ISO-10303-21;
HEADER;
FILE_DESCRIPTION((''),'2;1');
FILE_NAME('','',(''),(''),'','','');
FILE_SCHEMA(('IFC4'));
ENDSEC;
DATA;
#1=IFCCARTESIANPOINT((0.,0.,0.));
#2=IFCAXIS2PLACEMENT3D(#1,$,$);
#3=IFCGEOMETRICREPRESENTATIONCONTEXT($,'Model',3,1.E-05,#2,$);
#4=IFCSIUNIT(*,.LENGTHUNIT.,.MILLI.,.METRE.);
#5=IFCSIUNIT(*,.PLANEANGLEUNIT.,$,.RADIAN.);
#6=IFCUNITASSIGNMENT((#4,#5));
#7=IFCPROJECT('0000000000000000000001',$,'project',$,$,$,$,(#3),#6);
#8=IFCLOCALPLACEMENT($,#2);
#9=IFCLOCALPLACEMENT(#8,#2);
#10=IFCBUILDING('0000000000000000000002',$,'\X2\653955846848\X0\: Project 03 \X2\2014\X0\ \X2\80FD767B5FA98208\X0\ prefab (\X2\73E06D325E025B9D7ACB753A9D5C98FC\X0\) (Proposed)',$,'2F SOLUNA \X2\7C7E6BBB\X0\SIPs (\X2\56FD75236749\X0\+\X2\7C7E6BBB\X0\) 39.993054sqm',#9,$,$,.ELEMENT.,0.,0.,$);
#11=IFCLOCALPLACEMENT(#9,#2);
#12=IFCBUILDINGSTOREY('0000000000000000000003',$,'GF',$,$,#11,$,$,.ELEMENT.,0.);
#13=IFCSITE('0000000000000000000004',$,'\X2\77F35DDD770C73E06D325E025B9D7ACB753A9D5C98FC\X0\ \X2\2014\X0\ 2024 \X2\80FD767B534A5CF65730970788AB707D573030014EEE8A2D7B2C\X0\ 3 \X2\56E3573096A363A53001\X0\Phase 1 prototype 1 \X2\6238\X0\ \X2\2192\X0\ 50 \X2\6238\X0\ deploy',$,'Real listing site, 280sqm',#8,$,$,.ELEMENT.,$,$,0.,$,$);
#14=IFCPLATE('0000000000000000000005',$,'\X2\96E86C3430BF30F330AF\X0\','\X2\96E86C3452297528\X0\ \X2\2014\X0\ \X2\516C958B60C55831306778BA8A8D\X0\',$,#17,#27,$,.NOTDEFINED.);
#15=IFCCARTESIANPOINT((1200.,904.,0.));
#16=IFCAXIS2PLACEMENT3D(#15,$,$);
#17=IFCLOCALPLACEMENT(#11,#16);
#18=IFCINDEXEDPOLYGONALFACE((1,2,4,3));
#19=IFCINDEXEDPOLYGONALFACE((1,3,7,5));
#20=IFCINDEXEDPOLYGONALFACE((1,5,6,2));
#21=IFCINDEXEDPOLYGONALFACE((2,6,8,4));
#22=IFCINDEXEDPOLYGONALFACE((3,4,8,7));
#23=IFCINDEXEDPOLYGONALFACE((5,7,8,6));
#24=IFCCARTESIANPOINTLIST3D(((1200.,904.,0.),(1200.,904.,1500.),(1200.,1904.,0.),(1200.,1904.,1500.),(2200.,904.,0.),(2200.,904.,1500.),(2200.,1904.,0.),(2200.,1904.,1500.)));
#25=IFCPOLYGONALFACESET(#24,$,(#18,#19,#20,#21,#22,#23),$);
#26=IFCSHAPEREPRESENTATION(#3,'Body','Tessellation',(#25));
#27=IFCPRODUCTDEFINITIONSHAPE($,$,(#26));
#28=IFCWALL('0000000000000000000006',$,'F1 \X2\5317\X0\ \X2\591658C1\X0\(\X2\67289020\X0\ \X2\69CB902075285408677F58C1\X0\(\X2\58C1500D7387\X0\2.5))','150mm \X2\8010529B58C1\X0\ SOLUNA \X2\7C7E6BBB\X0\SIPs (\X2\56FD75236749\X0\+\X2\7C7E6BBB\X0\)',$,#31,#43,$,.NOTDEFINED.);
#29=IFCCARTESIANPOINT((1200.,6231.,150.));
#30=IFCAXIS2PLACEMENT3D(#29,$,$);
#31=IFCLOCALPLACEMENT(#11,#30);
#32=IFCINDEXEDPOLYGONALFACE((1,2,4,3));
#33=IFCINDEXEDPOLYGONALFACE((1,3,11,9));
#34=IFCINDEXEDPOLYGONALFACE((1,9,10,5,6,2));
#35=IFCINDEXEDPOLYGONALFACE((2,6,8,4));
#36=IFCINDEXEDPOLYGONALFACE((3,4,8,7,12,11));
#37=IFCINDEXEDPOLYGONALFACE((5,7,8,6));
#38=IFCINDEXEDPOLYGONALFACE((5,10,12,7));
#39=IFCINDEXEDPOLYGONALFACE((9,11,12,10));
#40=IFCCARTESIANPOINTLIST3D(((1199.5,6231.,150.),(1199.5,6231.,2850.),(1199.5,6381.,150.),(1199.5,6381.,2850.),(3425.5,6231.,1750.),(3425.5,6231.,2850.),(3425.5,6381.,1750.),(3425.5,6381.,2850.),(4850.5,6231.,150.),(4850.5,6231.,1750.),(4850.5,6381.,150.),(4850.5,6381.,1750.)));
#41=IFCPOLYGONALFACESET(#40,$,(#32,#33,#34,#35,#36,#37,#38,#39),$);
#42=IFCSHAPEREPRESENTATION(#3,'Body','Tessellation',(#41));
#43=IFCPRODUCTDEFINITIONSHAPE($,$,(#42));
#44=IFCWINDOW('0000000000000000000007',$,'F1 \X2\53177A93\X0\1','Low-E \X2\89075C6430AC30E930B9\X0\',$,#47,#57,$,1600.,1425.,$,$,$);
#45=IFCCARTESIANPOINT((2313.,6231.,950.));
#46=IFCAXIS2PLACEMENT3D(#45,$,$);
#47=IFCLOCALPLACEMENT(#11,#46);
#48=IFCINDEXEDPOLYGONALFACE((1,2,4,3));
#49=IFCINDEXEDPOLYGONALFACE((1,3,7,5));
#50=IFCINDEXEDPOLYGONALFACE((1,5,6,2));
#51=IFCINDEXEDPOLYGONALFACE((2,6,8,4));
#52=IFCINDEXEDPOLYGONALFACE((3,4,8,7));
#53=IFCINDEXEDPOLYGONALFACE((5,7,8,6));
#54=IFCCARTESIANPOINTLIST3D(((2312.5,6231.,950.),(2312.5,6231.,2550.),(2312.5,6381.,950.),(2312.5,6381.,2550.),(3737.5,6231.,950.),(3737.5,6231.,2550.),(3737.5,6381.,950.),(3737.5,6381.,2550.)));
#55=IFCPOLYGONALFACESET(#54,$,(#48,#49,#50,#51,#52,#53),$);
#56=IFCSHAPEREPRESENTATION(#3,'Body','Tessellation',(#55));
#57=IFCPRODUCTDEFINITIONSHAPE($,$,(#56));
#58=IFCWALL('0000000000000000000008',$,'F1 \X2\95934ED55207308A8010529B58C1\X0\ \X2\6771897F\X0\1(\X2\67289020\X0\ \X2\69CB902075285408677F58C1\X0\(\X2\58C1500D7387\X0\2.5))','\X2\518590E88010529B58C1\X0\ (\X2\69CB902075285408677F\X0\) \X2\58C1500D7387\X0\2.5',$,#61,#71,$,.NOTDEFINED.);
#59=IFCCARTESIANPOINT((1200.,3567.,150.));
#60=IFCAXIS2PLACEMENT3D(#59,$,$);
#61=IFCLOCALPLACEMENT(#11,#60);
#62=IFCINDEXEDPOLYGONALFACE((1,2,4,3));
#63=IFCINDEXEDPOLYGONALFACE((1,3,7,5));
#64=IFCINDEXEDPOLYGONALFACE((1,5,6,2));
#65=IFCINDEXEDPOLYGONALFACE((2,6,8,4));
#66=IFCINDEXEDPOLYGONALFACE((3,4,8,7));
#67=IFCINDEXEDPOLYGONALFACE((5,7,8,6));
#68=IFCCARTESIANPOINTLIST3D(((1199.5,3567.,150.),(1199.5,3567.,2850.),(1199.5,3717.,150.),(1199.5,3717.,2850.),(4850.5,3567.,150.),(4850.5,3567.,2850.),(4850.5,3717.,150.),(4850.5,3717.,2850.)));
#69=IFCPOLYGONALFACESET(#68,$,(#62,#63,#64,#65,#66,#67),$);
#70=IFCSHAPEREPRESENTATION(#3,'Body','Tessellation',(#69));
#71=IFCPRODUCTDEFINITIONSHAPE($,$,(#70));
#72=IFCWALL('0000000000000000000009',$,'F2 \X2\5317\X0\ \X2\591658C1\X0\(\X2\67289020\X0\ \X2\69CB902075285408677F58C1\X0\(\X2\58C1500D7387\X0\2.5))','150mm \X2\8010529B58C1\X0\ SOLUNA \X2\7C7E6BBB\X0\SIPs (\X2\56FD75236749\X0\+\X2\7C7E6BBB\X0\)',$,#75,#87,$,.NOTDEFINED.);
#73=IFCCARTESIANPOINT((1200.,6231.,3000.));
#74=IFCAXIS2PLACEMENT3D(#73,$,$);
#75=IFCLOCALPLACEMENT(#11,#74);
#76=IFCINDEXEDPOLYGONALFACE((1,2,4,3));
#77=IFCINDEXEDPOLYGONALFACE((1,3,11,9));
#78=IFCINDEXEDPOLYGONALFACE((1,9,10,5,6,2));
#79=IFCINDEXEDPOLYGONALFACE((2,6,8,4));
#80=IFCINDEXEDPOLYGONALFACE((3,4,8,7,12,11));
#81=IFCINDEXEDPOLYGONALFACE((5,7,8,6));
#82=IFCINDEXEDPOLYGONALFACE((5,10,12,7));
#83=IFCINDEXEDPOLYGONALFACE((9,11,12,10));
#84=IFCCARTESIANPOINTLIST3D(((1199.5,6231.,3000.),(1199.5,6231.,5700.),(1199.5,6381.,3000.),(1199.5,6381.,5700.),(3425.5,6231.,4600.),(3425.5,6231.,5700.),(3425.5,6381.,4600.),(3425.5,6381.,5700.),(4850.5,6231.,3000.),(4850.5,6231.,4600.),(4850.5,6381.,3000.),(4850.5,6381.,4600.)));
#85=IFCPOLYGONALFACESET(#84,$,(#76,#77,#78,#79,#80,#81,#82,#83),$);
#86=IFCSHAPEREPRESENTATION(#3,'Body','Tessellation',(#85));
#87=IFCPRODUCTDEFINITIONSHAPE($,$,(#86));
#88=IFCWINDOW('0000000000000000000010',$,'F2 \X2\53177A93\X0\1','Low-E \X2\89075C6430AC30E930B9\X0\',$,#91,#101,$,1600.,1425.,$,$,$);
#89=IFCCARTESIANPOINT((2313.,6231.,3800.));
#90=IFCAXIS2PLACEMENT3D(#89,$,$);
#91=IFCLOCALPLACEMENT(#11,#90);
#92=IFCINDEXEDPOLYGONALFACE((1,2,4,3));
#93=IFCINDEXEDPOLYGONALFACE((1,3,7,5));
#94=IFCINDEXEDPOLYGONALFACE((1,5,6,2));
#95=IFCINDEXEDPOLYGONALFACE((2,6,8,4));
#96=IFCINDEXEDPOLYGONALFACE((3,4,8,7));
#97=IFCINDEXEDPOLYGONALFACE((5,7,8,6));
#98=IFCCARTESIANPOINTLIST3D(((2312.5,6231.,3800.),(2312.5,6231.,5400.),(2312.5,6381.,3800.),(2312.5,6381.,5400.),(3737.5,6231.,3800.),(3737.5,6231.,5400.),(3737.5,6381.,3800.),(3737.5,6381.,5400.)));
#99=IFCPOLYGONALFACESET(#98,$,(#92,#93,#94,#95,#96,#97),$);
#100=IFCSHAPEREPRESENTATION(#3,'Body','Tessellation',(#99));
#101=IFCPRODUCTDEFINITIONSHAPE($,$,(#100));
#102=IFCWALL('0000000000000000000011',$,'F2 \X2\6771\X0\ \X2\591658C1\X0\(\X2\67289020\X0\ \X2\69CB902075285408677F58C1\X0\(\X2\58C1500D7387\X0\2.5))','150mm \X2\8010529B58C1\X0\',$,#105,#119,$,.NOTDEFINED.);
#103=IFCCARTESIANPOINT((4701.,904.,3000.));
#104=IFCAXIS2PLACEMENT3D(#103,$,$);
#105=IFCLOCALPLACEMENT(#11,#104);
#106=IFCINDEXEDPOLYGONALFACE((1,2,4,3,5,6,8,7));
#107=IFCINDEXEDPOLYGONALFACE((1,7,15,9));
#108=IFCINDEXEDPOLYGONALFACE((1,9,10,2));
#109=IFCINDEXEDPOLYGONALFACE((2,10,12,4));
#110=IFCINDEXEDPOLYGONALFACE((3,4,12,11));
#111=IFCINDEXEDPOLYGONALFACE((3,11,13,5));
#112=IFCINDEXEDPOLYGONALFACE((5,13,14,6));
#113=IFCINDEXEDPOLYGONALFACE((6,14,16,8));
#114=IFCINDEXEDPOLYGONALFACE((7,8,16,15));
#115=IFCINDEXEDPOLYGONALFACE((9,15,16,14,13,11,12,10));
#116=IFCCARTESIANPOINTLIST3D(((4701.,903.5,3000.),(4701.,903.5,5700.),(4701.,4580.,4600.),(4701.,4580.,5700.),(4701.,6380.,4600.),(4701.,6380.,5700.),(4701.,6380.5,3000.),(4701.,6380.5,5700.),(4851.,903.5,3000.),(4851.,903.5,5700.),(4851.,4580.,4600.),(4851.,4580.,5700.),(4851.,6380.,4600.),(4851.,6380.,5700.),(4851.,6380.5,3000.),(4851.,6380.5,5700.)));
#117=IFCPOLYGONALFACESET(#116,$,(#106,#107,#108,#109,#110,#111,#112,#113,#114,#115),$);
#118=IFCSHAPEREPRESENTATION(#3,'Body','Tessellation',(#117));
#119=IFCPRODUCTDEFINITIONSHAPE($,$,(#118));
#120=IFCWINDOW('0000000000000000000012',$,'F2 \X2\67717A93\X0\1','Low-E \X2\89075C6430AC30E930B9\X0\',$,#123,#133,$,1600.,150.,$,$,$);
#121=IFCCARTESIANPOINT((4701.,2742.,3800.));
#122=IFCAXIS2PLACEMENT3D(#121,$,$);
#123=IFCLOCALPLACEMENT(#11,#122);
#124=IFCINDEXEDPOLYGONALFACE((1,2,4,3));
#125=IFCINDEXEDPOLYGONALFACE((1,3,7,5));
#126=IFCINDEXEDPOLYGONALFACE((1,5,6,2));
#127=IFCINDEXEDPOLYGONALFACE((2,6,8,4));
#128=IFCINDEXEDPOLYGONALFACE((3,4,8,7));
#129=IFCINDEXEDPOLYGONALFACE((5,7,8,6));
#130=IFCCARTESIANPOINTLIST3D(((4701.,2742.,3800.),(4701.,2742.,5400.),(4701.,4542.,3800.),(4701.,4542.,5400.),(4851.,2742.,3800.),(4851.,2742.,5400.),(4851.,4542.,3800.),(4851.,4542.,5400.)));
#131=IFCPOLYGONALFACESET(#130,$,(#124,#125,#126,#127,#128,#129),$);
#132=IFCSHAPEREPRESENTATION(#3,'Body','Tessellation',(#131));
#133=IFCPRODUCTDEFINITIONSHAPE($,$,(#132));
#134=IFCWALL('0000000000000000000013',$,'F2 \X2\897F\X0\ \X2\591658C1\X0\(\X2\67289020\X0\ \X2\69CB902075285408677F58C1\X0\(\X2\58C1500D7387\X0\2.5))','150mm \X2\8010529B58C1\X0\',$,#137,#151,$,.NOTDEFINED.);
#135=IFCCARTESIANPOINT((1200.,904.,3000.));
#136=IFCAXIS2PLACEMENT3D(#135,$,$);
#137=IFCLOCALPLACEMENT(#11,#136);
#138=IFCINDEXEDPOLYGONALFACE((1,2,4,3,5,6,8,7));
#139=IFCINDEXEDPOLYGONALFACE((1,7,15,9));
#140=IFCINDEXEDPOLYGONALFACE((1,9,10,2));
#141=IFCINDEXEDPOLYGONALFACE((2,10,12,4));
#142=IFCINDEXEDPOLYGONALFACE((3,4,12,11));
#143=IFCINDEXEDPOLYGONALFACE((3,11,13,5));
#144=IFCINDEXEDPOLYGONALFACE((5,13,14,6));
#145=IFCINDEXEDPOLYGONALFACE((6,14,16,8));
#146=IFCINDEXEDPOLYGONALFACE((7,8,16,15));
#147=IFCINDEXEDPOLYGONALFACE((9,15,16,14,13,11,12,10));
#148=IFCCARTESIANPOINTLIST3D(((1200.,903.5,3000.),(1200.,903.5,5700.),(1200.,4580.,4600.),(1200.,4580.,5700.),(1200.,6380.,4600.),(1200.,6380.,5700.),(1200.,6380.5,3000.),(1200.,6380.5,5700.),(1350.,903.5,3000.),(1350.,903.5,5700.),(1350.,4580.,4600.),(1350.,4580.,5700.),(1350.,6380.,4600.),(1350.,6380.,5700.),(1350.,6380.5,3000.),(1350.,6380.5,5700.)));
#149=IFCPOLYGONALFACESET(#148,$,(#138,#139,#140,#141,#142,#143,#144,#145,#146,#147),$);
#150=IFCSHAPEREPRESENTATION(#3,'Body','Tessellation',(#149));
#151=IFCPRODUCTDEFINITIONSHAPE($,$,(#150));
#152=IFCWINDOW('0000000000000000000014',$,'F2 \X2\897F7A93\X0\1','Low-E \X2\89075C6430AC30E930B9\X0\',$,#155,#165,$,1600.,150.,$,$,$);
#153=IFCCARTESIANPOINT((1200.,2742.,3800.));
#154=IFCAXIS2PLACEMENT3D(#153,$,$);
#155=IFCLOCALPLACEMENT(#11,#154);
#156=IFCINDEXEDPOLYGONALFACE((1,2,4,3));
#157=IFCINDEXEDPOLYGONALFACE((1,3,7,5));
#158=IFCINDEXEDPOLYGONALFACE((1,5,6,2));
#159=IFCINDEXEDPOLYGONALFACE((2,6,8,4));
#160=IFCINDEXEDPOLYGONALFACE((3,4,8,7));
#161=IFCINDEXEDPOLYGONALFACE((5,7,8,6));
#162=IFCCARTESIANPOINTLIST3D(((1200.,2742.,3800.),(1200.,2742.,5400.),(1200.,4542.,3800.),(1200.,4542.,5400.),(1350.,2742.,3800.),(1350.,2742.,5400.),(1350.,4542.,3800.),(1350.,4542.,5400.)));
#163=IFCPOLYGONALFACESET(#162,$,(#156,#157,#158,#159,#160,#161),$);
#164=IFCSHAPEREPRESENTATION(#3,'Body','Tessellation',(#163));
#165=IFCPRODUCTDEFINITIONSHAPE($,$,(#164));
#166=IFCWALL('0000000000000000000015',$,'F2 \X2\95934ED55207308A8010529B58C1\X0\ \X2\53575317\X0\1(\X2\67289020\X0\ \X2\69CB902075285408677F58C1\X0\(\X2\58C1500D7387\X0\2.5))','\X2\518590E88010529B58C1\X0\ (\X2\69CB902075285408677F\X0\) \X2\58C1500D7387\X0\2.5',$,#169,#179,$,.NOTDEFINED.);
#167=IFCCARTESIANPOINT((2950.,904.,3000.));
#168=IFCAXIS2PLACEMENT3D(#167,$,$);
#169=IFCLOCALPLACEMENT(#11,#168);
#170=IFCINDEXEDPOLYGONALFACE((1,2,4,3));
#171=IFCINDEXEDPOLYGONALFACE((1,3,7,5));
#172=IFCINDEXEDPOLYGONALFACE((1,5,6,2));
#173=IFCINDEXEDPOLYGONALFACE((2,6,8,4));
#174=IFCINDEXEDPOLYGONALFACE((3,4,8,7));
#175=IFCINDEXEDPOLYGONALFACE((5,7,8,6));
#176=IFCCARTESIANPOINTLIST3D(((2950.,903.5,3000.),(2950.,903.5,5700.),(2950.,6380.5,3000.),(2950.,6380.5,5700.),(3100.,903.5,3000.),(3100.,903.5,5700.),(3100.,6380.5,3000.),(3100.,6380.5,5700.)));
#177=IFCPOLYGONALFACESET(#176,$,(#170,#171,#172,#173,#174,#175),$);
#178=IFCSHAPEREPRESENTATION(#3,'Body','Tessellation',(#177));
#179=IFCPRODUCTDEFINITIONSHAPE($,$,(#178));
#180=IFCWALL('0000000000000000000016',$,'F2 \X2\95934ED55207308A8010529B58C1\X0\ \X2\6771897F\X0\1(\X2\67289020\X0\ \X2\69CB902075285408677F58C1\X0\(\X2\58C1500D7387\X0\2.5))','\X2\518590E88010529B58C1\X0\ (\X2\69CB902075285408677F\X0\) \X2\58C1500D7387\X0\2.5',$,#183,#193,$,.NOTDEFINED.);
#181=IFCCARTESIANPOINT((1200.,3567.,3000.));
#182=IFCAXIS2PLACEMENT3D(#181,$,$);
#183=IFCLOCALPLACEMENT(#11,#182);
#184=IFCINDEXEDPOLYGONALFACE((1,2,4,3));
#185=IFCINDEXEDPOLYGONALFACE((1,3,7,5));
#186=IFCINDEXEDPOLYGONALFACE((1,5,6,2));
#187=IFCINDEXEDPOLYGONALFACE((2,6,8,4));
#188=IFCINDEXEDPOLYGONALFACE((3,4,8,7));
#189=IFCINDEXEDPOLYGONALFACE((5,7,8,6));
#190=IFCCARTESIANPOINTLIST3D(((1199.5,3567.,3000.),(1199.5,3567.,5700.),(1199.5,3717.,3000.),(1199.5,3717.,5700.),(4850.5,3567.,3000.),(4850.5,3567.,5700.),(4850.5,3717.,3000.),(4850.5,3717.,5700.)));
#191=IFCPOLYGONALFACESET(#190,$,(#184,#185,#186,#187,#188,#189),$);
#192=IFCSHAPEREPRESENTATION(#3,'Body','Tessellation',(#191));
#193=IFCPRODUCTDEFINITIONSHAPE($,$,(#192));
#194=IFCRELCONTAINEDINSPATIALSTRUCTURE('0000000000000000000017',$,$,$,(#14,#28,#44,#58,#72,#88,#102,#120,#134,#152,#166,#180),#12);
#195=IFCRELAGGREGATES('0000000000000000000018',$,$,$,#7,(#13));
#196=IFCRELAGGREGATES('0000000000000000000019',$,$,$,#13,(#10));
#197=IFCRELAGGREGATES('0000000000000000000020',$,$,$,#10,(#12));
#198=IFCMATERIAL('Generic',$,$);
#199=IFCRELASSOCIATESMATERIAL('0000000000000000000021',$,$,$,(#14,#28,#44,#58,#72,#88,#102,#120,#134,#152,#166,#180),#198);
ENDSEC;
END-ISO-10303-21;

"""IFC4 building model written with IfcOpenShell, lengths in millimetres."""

from ifc_helpers import new_model, si_unit, frame, frame_2d, origin, place, context, project, spatial, rectangle, extrude, material, element, fill, save


model = new_model("IFC4")

# Units and contexts
model_context = context("Model", 3, precision=1e-05, world=origin())
ifc_project = project(units=[si_unit("LENGTHUNIT", "METRE", prefix="MILLI"), si_unit("PLANEANGLEUNIT", "RADIAN")], contexts=[model_context])

# Site, building, storey
site_placement = place(None, origin())
site = spatial("IfcSite", under=ifc_project, at=site_placement, Name="石川県珠洲市宝立町鵜飼 — 2024 能登半島地震被災地、仮設第 3 団地隣接、Phase 1 prototype 1 戸 → 50 戸 deploy", ObjectType="Real listing site, 280sqm", CompositionType="ELEMENT", RefElevation=0.0)
building_placement = place(site_placement, origin())
building = spatial("IfcBuilding", under=site, at=building_placement, Name="改善案: Project 03 — 能登復興 prefab (珠洲市宝立町鵜飼) (Proposed)", ObjectType="2F SOLUNA 籾殻SIPs (国産杉+籾殻) 39.993054sqm", CompositionType="ELEMENT", ElevationOfRefHeight=0.0, ElevationOfTerrain=0.0)
storey_placement = place(building_placement, origin())
storey = spatial("IfcBuildingStorey", under=building, at=storey_placement, Name="GF", CompositionType="ELEMENT", Elevation=0.0)

# Plate
ifc_material_1 = material(Name="Generic")
plate_placement = place(storey_placement, frame((1200.0, 904.0, 0.0)))
element("IfcPlate", 1, at=plate_placement, inside=storey, material=ifc_material_1, Name="雨水タンク", Description="雨水利用 — 公開情報で確認", PredefinedType="NOTDEFINED", context=model_context, shape_type="SweptSolid", body=[
    extrude(rectangle(XDim=1000.0, YDim=1000.0, at=frame_2d((500.0, 500.0))), frame((1200.0, 904.0, 0.0)), (0.0, 0.0, 1.0), 1500.0),
])

# Wall, opening, window
wall_1_placement = place(storey_placement, frame((1200.0, 6231.0, 150.0)))
wall_1 = element("IfcWall", 2, at=wall_1_placement, inside=storey, material=ifc_material_1, Name="F1 北 外壁(木造 構造用合板壁(壁倍率2.5))", Description="150mm 耐力壁 SOLUNA 籾殻SIPs (国産杉+籾殻)", PredefinedType="NOTDEFINED", context=model_context, shape_type="SweptSolid", body=[
    extrude(rectangle(XDim=3651.0, YDim=150.0, at=frame_2d((1825.0, 75.0))), frame((1200.0, 6231.0, 150.0)), (0.0, 0.0, 1.0), 2700.0),
])
opening_1_placement = place(storey_placement, frame((2313.0, 6231.0, 950.0)))
opening_1 = element("IfcOpeningElement", 3, at=opening_1_placement, cuts=wall_1, PredefinedType="NOTDEFINED", context=model_context, shape_type="SweptSolid", body=[
    extrude(rectangle(XDim=1425.0, YDim=150.0, at=frame_2d((712.0, 75.0))), frame((2313.0, 6231.0, 950.0)), (0.0, 0.0, 1.0), 1600.0),
])
window_1_placement = place(storey_placement, frame((2313.0, 6231.0, 950.0)))
window_1 = element("IfcWindow", 4, at=window_1_placement, inside=storey, material=ifc_material_1, Name="F1 北窓1", Description="Low-E 複層ガラス", OverallHeight=1600.0, OverallWidth=1425.0, context=model_context, shape_type="SweptSolid", body=[
    extrude(rectangle(XDim=1425.0, YDim=150.0, at=frame_2d((712.0, 75.0))), frame((2313.0, 6231.0, 950.0)), (0.0, 0.0, 1.0), 1600.0),
])
fill(opening_1, window_1)

# Wall
wall_2_placement = place(storey_placement, frame((1200.0, 3567.0, 150.0)))
element("IfcWall", 5, at=wall_2_placement, inside=storey, material=ifc_material_1, Name="F1 間仕切り耐力壁 東西1(木造 構造用合板壁(壁倍率2.5))", Description="内部耐力壁 (構造用合板) 壁倍率2.5", PredefinedType="NOTDEFINED", context=model_context, shape_type="SweptSolid", body=[
    extrude(rectangle(XDim=3651.0, YDim=150.0, at=frame_2d((1825.0, 75.0))), frame((1200.0, 3567.0, 150.0)), (0.0, 0.0, 1.0), 2700.0),
])

# Walls, openings, windows
wall_3_placement = place(storey_placement, frame((1200.0, 6231.0, 3000.0)))
wall_3 = element("IfcWall", 6, at=wall_3_placement, inside=storey, material=ifc_material_1, Name="F2 北 外壁(木造 構造用合板壁(壁倍率2.5))", Description="150mm 耐力壁 SOLUNA 籾殻SIPs (国産杉+籾殻)", PredefinedType="NOTDEFINED", context=model_context, shape_type="SweptSolid", body=[
    extrude(rectangle(XDim=3651.0, YDim=150.0, at=frame_2d((1825.0, 75.0))), frame((1200.0, 6231.0, 3000.0)), (0.0, 0.0, 1.0), 2700.0),
])
opening_2_placement = place(storey_placement, frame((2313.0, 6231.0, 3800.0)))
opening_2 = element("IfcOpeningElement", 7, at=opening_2_placement, cuts=wall_3, PredefinedType="NOTDEFINED", context=model_context, shape_type="SweptSolid", body=[
    extrude(rectangle(XDim=1425.0, YDim=150.0, at=frame_2d((712.0, 75.0))), frame((2313.0, 6231.0, 3800.0)), (0.0, 0.0, 1.0), 1600.0),
])
window_2_placement = place(storey_placement, frame((2313.0, 6231.0, 3800.0)))
window_2 = element("IfcWindow", 8, at=window_2_placement, inside=storey, material=ifc_material_1, Name="F2 北窓1", Description="Low-E 複層ガラス", OverallHeight=1600.0, OverallWidth=1425.0, context=model_context, shape_type="SweptSolid", body=[
    extrude(rectangle(XDim=1425.0, YDim=150.0, at=frame_2d((712.0, 75.0))), frame((2313.0, 6231.0, 3800.0)), (0.0, 0.0, 1.0), 1600.0),
])
fill(opening_2, window_2)
wall_4_placement = place(storey_placement, frame((4701.0, 904.0, 3000.0)))
wall_4 = element("IfcWall", 9, at=wall_4_placement, inside=storey, material=ifc_material_1, Name="F2 東 外壁(木造 構造用合板壁(壁倍率2.5))", Description="150mm 耐力壁", PredefinedType="NOTDEFINED", context=model_context, shape_type="SweptSolid", body=[
    extrude(rectangle(XDim=150.0, YDim=5477.0, at=frame_2d((75.0, 2738.0))), frame((4701.0, 904.0, 3000.0)), (0.0, 0.0, 1.0), 2700.0),
])
opening_3_placement = place(storey_placement, frame((4701.0, 2742.0, 3800.0)))
opening_3 = element("IfcOpeningElement", 10, at=opening_3_placement, cuts=wall_4, PredefinedType="NOTDEFINED", context=model_context, shape_type="SweptSolid", body=[
    extrude(rectangle(XDim=150.0, YDim=1800.0, at=frame_2d((75.0, 900.0))), frame((4701.0, 2742.0, 3800.0)), (0.0, 0.0, 1.0), 1600.0),
])
window_3_placement = place(storey_placement, frame((4701.0, 2742.0, 3800.0)))
window_3 = element("IfcWindow", 11, at=window_3_placement, inside=storey, material=ifc_material_1, Name="F2 東窓1", Description="Low-E 複層ガラス", OverallHeight=1600.0, OverallWidth=150.0, context=model_context, shape_type="SweptSolid", body=[
    extrude(rectangle(XDim=150.0, YDim=1800.0, at=frame_2d((75.0, 900.0))), frame((4701.0, 2742.0, 3800.0)), (0.0, 0.0, 1.0), 1600.0),
])
fill(opening_3, window_3)
wall_5_placement = place(storey_placement, frame((1200.0, 904.0, 3000.0)))
wall_5 = element("IfcWall", 12, at=wall_5_placement, inside=storey, material=ifc_material_1, Name="F2 西 外壁(木造 構造用合板壁(壁倍率2.5))", Description="150mm 耐力壁", PredefinedType="NOTDEFINED", context=model_context, shape_type="SweptSolid", body=[
    extrude(rectangle(XDim=150.0, YDim=5477.0, at=frame_2d((75.0, 2738.0))), frame((1200.0, 904.0, 3000.0)), (0.0, 0.0, 1.0), 2700.0),
])
opening_4_placement = place(storey_placement, frame((1200.0, 2742.0, 3800.0)))
opening_4 = element("IfcOpeningElement", 13, at=opening_4_placement, cuts=wall_5, PredefinedType="NOTDEFINED", context=model_context, shape_type="SweptSolid", body=[
    extrude(rectangle(XDim=150.0, YDim=1800.0, at=frame_2d((75.0, 900.0))), frame((1200.0, 2742.0, 3800.0)), (0.0, 0.0, 1.0), 1600.0),
])
window_4_placement = place(storey_placement, frame((1200.0, 2742.0, 3800.0)))
window_4 = element("IfcWindow", 14, at=window_4_placement, inside=storey, material=ifc_material_1, Name="F2 西窓1", Description="Low-E 複層ガラス", OverallHeight=1600.0, OverallWidth=150.0, context=model_context, shape_type="SweptSolid", body=[
    extrude(rectangle(XDim=150.0, YDim=1800.0, at=frame_2d((75.0, 900.0))), frame((1200.0, 2742.0, 3800.0)), (0.0, 0.0, 1.0), 1600.0),
])
fill(opening_4, window_4)

# Walls
wall_6_placement = place(storey_placement, frame((2950.0, 904.0, 3000.0)))
element("IfcWall", 15, at=wall_6_placement, inside=storey, material=ifc_material_1, Name="F2 間仕切り耐力壁 南北1(木造 構造用合板壁(壁倍率2.5))", Description="内部耐力壁 (構造用合板) 壁倍率2.5", PredefinedType="NOTDEFINED", context=model_context, shape_type="SweptSolid", body=[
    extrude(rectangle(XDim=150.0, YDim=5477.0, at=frame_2d((75.0, 2738.0))), frame((2950.0, 904.0, 3000.0)), (0.0, 0.0, 1.0), 2700.0),
])
wall_7_placement = place(storey_placement, frame((1200.0, 3567.0, 3000.0)))
element("IfcWall", 16, at=wall_7_placement, inside=storey, material=ifc_material_1, Name="F2 間仕切り耐力壁 東西1(木造 構造用合板壁(壁倍率2.5))", Description="内部耐力壁 (構造用合板) 壁倍率2.5", PredefinedType="NOTDEFINED", context=model_context, shape_type="SweptSolid", body=[
    extrude(rectangle(XDim=3651.0, YDim=150.0, at=frame_2d((1825.0, 75.0))), frame((1200.0, 3567.0, 3000.0)), (0.0, 0.0, 1.0), 2700.0),
])

save(model, "model.ifc")
